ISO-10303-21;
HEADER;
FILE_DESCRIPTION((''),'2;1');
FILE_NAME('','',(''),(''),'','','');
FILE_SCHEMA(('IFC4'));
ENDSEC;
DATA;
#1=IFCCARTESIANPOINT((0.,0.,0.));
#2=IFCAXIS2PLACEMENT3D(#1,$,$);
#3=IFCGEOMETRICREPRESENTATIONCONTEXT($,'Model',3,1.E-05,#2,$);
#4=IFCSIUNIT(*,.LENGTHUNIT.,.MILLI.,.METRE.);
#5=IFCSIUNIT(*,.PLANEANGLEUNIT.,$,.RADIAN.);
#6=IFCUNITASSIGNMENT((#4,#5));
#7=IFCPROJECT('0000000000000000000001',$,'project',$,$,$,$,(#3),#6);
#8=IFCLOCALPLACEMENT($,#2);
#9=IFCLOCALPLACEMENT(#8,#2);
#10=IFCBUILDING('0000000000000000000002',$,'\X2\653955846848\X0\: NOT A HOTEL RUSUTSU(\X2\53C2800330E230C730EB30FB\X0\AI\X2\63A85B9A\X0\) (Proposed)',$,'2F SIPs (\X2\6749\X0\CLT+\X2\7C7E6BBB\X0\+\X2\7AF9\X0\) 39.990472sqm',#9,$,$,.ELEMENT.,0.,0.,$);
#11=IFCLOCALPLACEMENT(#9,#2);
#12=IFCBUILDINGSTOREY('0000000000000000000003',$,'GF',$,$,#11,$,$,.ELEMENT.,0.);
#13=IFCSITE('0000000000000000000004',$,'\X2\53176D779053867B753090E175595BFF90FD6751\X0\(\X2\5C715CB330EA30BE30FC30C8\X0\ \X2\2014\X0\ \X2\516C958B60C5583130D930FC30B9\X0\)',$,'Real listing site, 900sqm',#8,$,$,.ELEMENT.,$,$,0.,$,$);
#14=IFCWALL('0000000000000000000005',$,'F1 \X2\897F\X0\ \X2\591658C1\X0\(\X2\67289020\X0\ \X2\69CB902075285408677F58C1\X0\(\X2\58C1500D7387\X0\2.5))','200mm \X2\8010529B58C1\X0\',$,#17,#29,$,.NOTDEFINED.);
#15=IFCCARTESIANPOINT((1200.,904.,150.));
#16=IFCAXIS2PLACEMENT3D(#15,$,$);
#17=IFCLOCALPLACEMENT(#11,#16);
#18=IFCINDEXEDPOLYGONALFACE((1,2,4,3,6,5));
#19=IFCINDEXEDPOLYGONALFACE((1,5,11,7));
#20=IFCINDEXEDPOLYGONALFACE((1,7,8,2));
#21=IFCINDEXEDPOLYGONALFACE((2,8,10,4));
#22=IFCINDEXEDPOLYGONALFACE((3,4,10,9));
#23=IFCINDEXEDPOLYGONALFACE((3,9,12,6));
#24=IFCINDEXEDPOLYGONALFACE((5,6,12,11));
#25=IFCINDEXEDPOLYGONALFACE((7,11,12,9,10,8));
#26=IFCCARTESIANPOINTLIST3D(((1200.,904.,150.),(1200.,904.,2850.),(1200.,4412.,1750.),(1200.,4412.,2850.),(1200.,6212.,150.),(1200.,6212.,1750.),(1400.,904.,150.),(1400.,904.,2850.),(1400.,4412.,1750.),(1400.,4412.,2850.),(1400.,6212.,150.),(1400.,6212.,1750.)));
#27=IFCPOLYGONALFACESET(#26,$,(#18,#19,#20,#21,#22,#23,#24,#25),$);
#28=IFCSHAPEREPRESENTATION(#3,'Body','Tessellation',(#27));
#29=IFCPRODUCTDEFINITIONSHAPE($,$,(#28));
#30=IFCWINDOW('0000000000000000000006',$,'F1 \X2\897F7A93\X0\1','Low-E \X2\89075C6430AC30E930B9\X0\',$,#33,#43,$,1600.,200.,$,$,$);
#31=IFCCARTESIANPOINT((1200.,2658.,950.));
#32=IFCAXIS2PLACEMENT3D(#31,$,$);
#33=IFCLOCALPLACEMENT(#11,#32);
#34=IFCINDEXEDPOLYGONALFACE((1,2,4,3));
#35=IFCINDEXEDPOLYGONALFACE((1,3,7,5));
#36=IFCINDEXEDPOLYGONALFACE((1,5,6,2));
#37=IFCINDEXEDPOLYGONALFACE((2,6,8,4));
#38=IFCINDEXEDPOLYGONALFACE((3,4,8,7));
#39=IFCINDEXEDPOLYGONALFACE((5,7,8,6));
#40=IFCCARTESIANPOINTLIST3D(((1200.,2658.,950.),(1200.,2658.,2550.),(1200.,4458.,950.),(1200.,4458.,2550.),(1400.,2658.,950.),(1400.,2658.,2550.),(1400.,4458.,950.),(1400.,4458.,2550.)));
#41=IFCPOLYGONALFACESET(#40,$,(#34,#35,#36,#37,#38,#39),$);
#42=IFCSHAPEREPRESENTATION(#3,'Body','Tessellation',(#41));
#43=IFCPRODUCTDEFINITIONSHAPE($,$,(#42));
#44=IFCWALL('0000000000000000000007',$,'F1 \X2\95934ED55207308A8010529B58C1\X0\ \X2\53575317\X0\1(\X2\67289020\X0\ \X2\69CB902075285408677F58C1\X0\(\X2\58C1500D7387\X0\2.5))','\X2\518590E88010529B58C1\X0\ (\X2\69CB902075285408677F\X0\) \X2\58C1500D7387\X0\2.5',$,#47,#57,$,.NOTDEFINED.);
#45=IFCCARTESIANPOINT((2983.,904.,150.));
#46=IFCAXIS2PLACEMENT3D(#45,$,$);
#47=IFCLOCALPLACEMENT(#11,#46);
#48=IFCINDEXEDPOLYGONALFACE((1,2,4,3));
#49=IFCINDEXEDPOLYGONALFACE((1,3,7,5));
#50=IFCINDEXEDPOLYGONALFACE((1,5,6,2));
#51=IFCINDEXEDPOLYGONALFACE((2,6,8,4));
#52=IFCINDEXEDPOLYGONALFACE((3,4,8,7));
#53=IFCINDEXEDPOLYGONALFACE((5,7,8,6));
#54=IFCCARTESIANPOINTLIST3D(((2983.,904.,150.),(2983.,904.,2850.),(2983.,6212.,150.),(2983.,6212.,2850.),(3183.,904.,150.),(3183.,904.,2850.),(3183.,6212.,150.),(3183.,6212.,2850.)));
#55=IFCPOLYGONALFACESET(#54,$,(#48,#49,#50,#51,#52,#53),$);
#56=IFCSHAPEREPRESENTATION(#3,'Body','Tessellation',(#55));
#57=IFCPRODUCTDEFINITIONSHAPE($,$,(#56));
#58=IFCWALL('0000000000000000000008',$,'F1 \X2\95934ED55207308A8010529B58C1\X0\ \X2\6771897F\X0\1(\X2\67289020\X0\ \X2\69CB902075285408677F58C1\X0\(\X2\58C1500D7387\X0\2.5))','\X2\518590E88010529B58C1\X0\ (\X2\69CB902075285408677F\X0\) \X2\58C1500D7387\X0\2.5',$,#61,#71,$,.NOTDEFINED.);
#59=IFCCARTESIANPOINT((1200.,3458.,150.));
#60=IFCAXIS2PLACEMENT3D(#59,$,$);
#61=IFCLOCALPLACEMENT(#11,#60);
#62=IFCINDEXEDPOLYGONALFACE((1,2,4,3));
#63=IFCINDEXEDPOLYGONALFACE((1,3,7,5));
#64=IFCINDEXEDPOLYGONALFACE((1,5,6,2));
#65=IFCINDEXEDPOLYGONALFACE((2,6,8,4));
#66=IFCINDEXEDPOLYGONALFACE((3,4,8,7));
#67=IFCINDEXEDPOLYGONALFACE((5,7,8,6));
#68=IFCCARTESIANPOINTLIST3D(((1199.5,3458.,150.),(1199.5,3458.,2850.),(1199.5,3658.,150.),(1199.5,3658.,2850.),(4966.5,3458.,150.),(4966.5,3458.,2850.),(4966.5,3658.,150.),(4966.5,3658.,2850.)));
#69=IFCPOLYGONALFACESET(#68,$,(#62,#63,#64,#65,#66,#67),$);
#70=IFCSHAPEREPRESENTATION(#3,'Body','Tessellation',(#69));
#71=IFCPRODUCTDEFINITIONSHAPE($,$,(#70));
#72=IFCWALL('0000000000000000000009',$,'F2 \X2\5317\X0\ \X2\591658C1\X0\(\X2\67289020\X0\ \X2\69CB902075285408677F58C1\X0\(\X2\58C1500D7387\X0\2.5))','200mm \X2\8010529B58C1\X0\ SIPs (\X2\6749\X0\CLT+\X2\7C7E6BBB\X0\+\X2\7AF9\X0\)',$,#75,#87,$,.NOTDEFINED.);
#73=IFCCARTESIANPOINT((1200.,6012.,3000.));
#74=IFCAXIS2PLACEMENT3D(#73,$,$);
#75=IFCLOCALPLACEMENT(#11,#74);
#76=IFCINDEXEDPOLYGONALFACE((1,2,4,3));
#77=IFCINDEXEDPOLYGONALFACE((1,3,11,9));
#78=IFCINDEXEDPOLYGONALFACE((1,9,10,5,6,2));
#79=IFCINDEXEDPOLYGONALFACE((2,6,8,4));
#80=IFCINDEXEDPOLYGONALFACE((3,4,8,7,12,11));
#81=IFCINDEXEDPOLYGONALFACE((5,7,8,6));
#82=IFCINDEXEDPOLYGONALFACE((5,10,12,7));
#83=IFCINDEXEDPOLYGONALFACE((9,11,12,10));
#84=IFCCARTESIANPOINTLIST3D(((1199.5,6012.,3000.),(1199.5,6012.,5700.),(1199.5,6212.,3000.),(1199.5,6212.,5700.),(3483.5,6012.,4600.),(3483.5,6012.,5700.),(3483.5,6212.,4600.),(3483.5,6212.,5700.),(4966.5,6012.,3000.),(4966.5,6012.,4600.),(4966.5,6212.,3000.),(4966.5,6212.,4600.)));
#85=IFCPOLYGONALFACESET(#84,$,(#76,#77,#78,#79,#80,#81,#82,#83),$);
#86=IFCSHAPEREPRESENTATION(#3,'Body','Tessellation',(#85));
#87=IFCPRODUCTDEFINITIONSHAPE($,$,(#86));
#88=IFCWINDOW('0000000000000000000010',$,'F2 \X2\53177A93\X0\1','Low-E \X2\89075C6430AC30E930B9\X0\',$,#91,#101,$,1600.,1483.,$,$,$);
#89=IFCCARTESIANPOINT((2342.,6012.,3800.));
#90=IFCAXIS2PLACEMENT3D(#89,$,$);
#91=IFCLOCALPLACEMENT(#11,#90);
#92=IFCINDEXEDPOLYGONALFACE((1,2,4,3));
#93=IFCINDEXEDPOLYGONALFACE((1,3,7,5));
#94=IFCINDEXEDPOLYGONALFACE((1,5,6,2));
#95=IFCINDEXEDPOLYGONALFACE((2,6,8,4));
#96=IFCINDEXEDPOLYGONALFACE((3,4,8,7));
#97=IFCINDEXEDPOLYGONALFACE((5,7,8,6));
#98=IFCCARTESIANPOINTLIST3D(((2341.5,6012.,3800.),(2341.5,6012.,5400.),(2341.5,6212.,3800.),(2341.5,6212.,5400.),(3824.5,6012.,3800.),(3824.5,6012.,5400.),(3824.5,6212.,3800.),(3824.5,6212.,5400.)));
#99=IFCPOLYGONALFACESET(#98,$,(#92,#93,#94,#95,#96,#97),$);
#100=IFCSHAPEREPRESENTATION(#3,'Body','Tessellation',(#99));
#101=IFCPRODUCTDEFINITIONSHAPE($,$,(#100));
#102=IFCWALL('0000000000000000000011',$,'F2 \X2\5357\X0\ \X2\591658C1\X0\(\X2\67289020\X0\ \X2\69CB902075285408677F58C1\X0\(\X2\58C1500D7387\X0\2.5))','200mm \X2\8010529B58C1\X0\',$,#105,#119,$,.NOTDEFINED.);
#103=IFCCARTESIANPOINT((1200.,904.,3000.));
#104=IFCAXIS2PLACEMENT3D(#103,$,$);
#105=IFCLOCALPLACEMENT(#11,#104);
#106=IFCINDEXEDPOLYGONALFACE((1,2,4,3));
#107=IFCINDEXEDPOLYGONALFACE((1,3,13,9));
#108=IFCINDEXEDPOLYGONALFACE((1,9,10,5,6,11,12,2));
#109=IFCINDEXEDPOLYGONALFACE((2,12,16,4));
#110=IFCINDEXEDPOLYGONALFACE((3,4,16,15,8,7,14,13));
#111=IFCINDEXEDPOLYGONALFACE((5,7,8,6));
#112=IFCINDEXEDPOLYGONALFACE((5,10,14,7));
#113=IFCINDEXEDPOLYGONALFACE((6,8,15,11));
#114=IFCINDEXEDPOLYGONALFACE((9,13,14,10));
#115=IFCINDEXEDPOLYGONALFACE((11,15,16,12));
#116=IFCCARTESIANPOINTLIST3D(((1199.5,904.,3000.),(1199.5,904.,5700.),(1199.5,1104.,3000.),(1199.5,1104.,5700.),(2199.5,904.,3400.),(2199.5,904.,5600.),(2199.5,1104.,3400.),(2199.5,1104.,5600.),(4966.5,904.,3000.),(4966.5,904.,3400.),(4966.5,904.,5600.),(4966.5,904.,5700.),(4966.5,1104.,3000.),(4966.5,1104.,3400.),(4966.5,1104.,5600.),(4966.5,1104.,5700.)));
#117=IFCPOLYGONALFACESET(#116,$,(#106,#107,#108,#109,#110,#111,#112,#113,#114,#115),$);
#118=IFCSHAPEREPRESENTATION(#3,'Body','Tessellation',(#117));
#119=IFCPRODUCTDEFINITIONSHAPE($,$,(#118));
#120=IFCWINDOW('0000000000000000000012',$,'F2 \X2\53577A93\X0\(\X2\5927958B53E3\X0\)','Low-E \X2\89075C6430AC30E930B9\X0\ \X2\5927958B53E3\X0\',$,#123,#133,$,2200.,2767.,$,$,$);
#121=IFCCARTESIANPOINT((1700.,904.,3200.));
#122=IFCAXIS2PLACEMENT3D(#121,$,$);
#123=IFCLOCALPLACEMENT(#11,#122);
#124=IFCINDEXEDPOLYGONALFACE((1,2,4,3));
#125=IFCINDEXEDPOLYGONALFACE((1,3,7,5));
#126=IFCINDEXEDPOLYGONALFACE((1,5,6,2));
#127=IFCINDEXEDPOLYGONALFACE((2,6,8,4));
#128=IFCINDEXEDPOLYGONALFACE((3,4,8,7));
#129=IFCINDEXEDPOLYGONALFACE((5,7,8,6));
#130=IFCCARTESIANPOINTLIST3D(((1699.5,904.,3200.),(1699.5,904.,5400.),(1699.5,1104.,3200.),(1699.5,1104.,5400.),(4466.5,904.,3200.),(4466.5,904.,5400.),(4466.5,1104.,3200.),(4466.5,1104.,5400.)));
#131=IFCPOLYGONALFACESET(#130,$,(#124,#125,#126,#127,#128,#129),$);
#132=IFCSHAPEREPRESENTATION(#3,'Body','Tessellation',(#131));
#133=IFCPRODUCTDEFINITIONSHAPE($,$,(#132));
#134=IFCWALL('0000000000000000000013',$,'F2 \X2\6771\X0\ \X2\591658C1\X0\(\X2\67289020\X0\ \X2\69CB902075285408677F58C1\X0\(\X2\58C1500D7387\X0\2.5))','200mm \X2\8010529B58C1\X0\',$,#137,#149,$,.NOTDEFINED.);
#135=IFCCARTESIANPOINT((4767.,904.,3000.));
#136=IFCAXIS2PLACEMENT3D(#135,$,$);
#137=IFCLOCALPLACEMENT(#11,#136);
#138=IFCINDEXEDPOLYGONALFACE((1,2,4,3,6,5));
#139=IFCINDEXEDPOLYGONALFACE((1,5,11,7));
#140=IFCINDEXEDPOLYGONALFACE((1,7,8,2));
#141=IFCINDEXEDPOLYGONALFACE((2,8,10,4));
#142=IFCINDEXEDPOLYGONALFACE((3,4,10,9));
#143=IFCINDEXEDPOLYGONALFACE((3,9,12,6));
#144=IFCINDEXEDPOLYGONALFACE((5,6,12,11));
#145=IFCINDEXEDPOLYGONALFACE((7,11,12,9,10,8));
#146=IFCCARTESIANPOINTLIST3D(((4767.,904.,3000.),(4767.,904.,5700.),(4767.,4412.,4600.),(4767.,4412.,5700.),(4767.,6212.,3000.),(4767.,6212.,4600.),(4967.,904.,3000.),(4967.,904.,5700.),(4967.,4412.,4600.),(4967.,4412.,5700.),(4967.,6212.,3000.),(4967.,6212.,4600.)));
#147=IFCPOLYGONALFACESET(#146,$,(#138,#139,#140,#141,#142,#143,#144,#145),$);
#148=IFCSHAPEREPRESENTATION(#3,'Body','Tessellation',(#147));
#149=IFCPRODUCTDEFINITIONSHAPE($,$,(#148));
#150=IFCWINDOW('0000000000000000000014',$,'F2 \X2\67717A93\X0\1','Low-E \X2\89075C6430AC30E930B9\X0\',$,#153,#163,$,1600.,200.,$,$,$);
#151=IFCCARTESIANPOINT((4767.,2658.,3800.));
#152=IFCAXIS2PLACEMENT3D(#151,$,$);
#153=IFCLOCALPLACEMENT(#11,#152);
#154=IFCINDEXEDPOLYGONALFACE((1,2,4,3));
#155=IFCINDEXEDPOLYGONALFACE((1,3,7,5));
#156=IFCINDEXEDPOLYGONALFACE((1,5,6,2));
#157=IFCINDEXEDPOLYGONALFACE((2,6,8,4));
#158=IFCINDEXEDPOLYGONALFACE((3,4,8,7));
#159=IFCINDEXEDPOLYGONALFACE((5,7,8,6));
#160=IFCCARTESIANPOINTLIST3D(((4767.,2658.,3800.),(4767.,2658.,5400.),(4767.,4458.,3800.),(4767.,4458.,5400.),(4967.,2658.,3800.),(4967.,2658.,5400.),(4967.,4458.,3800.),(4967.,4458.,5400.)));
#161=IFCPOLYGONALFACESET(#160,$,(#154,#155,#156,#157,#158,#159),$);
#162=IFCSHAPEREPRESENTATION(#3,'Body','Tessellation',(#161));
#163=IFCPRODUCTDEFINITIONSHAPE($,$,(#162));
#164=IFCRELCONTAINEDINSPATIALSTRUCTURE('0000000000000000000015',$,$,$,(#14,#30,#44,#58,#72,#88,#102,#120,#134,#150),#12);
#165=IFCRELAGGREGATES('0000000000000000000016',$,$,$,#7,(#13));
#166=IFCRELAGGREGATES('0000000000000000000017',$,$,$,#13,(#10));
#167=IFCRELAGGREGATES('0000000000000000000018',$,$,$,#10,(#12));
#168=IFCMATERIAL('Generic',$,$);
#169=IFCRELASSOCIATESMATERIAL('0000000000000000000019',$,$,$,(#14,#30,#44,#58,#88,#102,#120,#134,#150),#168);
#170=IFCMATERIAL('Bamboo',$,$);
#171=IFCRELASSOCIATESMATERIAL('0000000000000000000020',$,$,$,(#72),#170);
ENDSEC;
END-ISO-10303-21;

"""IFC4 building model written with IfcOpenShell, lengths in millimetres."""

from ifc_helpers import new_model, si_unit, frame, frame_2d, origin, place, context, project, spatial, rectangle, extrude, material, element, fill, save


model = new_model("IFC4")

# Units and contexts
model_context = context("Model", 3, precision=1e-05, world=origin())
ifc_project = project(units=[si_unit("LENGTHUNIT", "METRE", prefix="MILLI"), si_unit("PLANEANGLEUNIT", "RADIAN")], contexts=[model_context])

# Site, building, storey
site_placement = place(None, origin())
site = spatial("IfcSite", under=ifc_project, at=site_placement, Name="北海道虻田郡留寿都村(山岳リゾート — 公開情報ベース)", ObjectType="Real listing site, 900sqm", CompositionType="ELEMENT", RefElevation=0.0)
building_placement = place(site_placement, origin())
building = spatial("IfcBuilding", under=site, at=building_placement, Name="改善案: NOT A HOTEL RUSUTSU(参考モデル・AI推定) (Proposed)", ObjectType="2F SIPs (杉CLT+籾殻+竹) 39.990472sqm", CompositionType="ELEMENT", ElevationOfRefHeight=0.0, ElevationOfTerrain=0.0)
storey_placement = place(building_placement, origin())
storey = spatial("IfcBuildingStorey", under=building, at=storey_placement, Name="GF", CompositionType="ELEMENT", Elevation=0.0)

# Shared definitions
ifc_material_1 = material(Name="Generic")

# Shared definitions
ifc_material_2 = material(Name="Bamboo")

# Wall, opening, window
wall_1_placement = place(storey_placement, frame((1200.0, 904.0, 150.0)))
wall_1 = element("IfcWall", 1, at=wall_1_placement, inside=storey, material=ifc_material_1, Name="F1 西 外壁(木造 構造用合板壁(壁倍率2.5))", Description="200mm 耐力壁", PredefinedType="NOTDEFINED", context=model_context, shape_type="SweptSolid", body=[
    extrude(rectangle(XDim=200.0, YDim=5308.0, at=frame_2d((100.0, 2654.0))), frame((1200.0, 904.0, 150.0)), (0.0, 0.0, 1.0), 2700.0),
])
opening_1_placement = place(storey_placement, frame((1200.0, 2658.0, 950.0)))
opening_1 = element("IfcOpeningElement", 2, at=opening_1_placement, cuts=wall_1, PredefinedType="NOTDEFINED", context=model_context, shape_type="SweptSolid", body=[
    extrude(rectangle(XDim=200.0, YDim=1800.0, at=frame_2d((100.0, 900.0))), frame((1200.0, 2658.0, 950.0)), (0.0, 0.0, 1.0), 1600.0),
])
window_1_placement = place(storey_placement, frame((1200.0, 2658.0, 950.0)))
window_1 = element("IfcWindow", 3, at=window_1_placement, inside=storey, material=ifc_material_1, Name="F1 西窓1", Description="Low-E 複層ガラス", OverallHeight=1600.0, OverallWidth=200.0, context=model_context, shape_type="SweptSolid", body=[
    extrude(rectangle(XDim=200.0, YDim=1800.0, at=frame_2d((100.0, 900.0))), frame((1200.0, 2658.0, 950.0)), (0.0, 0.0, 1.0), 1600.0),
])
fill(opening_1, window_1)

# Walls
wall_2_placement = place(storey_placement, frame((2983.0, 904.0, 150.0)))
element("IfcWall", 4, at=wall_2_placement, inside=storey, material=ifc_material_1, Name="F1 間仕切り耐力壁 南北1(木造 構造用合板壁(壁倍率2.5))", Description="内部耐力壁 (構造用合板) 壁倍率2.5", PredefinedType="NOTDEFINED", context=model_context, shape_type="SweptSolid", body=[
    extrude(rectangle(XDim=200.0, YDim=5308.0, at=frame_2d((100.0, 2654.0))), frame((2983.0, 904.0, 150.0)), (0.0, 0.0, 1.0), 2700.0),
])
wall_3_placement = place(storey_placement, frame((1200.0, 3458.0, 150.0)))
element("IfcWall", 5, at=wall_3_placement, inside=storey, material=ifc_material_1, Name="F1 間仕切り耐力壁 東西1(木造 構造用合板壁(壁倍率2.5))", Description="内部耐力壁 (構造用合板) 壁倍率2.5", PredefinedType="NOTDEFINED", context=model_context, shape_type="SweptSolid", body=[
    extrude(rectangle(XDim=3767.0, YDim=200.0, at=frame_2d((1883.0, 100.0))), frame((1200.0, 3458.0, 150.0)), (0.0, 0.0, 1.0), 2700.0),
])

# Walls, openings, windows
wall_4_placement = place(storey_placement, frame((1200.0, 6012.0, 3000.0)))
wall_4 = element("IfcWall", 6, at=wall_4_placement, inside=storey, material=ifc_material_2, Name="F2 北 外壁(木造 構造用合板壁(壁倍率2.5))", Description="200mm 耐力壁 SIPs (杉CLT+籾殻+竹)", PredefinedType="NOTDEFINED", context=model_context, shape_type="SweptSolid", body=[
    extrude(rectangle(XDim=3767.0, YDim=200.0, at=frame_2d((1883.0, 100.0))), frame((1200.0, 6012.0, 3000.0)), (0.0, 0.0, 1.0), 2700.0),
])
opening_2_placement = place(storey_placement, frame((2342.0, 6012.0, 3800.0)))
opening_2 = element("IfcOpeningElement", 7, at=opening_2_placement, cuts=wall_4, PredefinedType="NOTDEFINED", context=model_context, shape_type="SweptSolid", body=[
    extrude(rectangle(XDim=1483.0, YDim=200.0, at=frame_2d((741.0, 100.0))), frame((2342.0, 6012.0, 3800.0)), (0.0, 0.0, 1.0), 1600.0),
])
window_2_placement = place(storey_placement, frame((2342.0, 6012.0, 3800.0)))
window_2 = element("IfcWindow", 8, at=window_2_placement, inside=storey, material=ifc_material_1, Name="F2 北窓1", Description="Low-E 複層ガラス", OverallHeight=1600.0, OverallWidth=1483.0, context=model_context, shape_type="SweptSolid", body=[
    extrude(rectangle(XDim=1483.0, YDim=200.0, at=frame_2d((741.0, 100.0))), frame((2342.0, 6012.0, 3800.0)), (0.0, 0.0, 1.0), 1600.0),
])
fill(opening_2, window_2)
wall_5_placement = place(storey_placement, frame((1200.0, 904.0, 3000.0)))
wall_5 = element("IfcWall", 9, at=wall_5_placement, inside=storey, material=ifc_material_1, Name="F2 南 外壁(木造 構造用合板壁(壁倍率2.5))", Description="200mm 耐力壁", PredefinedType="NOTDEFINED", context=model_context, shape_type="SweptSolid", body=[
    extrude(rectangle(XDim=3767.0, YDim=200.0, at=frame_2d((1883.0, 100.0))), frame((1200.0, 904.0, 3000.0)), (0.0, 0.0, 1.0), 2700.0),
])
opening_3_placement = place(storey_placement, frame((1700.0, 904.0, 3200.0)))
opening_3 = element("IfcOpeningElement", 10, at=opening_3_placement, cuts=wall_5, PredefinedType="NOTDEFINED", context=model_context, shape_type="SweptSolid", body=[
    extrude(rectangle(XDim=2767.0, YDim=200.0, at=frame_2d((1383.0, 100.0))), frame((1700.0, 904.0, 3200.0)), (0.0, 0.0, 1.0), 2200.0),
])
window_3_placement = place(storey_placement, frame((1700.0, 904.0, 3200.0)))
window_3 = element("IfcWindow", 11, at=window_3_placement, inside=storey, material=ifc_material_1, Name="F2 南窓(大開口)", Description="Low-E 複層ガラス 大開口", OverallHeight=2200.0, OverallWidth=2767.0, context=model_context, shape_type="SweptSolid", body=[
    extrude(rectangle(XDim=2767.0, YDim=200.0, at=frame_2d((1383.0, 100.0))), frame((1700.0, 904.0, 3200.0)), (0.0, 0.0, 1.0), 2200.0),
])
fill(opening_3, window_3)
wall_6_placement = place(storey_placement, frame((4767.0, 904.0, 3000.0)))
wall_6 = element("IfcWall", 12, at=wall_6_placement, inside=storey, material=ifc_material_1, Name="F2 東 外壁(木造 構造用合板壁(壁倍率2.5))", Description="200mm 耐力壁", PredefinedType="NOTDEFINED", context=model_context, shape_type="SweptSolid", body=[
    extrude(rectangle(XDim=200.0, YDim=5308.0, at=frame_2d((100.0, 2654.0))), frame((4767.0, 904.0, 3000.0)), (0.0, 0.0, 1.0), 2700.0),
])
opening_4_placement = place(storey_placement, frame((4767.0, 2658.0, 3800.0)))
opening_4 = element("IfcOpeningElement", 13, at=opening_4_placement, cuts=wall_6, PredefinedType="NOTDEFINED", context=model_context, shape_type="SweptSolid", body=[
    extrude(rectangle(XDim=200.0, YDim=1800.0, at=frame_2d((100.0, 900.0))), frame((4767.0, 2658.0, 3800.0)), (0.0, 0.0, 1.0), 1600.0),
])
window_4_placement = place(storey_placement, frame((4767.0, 2658.0, 3800.0)))
window_4 = element("IfcWindow", 14, at=window_4_placement, inside=storey, material=ifc_material_1, Name="F2 東窓1", Description="Low-E 複層ガラス", OverallHeight=1600.0, OverallWidth=200.0, context=model_context, shape_type="SweptSolid", body=[
    extrude(rectangle(XDim=200.0, YDim=1800.0, at=frame_2d((100.0, 900.0))), frame((4767.0, 2658.0, 3800.0)), (0.0, 0.0, 1.0), 1600.0),
])
fill(opening_4, window_4)

save(model, "model.ifc")
